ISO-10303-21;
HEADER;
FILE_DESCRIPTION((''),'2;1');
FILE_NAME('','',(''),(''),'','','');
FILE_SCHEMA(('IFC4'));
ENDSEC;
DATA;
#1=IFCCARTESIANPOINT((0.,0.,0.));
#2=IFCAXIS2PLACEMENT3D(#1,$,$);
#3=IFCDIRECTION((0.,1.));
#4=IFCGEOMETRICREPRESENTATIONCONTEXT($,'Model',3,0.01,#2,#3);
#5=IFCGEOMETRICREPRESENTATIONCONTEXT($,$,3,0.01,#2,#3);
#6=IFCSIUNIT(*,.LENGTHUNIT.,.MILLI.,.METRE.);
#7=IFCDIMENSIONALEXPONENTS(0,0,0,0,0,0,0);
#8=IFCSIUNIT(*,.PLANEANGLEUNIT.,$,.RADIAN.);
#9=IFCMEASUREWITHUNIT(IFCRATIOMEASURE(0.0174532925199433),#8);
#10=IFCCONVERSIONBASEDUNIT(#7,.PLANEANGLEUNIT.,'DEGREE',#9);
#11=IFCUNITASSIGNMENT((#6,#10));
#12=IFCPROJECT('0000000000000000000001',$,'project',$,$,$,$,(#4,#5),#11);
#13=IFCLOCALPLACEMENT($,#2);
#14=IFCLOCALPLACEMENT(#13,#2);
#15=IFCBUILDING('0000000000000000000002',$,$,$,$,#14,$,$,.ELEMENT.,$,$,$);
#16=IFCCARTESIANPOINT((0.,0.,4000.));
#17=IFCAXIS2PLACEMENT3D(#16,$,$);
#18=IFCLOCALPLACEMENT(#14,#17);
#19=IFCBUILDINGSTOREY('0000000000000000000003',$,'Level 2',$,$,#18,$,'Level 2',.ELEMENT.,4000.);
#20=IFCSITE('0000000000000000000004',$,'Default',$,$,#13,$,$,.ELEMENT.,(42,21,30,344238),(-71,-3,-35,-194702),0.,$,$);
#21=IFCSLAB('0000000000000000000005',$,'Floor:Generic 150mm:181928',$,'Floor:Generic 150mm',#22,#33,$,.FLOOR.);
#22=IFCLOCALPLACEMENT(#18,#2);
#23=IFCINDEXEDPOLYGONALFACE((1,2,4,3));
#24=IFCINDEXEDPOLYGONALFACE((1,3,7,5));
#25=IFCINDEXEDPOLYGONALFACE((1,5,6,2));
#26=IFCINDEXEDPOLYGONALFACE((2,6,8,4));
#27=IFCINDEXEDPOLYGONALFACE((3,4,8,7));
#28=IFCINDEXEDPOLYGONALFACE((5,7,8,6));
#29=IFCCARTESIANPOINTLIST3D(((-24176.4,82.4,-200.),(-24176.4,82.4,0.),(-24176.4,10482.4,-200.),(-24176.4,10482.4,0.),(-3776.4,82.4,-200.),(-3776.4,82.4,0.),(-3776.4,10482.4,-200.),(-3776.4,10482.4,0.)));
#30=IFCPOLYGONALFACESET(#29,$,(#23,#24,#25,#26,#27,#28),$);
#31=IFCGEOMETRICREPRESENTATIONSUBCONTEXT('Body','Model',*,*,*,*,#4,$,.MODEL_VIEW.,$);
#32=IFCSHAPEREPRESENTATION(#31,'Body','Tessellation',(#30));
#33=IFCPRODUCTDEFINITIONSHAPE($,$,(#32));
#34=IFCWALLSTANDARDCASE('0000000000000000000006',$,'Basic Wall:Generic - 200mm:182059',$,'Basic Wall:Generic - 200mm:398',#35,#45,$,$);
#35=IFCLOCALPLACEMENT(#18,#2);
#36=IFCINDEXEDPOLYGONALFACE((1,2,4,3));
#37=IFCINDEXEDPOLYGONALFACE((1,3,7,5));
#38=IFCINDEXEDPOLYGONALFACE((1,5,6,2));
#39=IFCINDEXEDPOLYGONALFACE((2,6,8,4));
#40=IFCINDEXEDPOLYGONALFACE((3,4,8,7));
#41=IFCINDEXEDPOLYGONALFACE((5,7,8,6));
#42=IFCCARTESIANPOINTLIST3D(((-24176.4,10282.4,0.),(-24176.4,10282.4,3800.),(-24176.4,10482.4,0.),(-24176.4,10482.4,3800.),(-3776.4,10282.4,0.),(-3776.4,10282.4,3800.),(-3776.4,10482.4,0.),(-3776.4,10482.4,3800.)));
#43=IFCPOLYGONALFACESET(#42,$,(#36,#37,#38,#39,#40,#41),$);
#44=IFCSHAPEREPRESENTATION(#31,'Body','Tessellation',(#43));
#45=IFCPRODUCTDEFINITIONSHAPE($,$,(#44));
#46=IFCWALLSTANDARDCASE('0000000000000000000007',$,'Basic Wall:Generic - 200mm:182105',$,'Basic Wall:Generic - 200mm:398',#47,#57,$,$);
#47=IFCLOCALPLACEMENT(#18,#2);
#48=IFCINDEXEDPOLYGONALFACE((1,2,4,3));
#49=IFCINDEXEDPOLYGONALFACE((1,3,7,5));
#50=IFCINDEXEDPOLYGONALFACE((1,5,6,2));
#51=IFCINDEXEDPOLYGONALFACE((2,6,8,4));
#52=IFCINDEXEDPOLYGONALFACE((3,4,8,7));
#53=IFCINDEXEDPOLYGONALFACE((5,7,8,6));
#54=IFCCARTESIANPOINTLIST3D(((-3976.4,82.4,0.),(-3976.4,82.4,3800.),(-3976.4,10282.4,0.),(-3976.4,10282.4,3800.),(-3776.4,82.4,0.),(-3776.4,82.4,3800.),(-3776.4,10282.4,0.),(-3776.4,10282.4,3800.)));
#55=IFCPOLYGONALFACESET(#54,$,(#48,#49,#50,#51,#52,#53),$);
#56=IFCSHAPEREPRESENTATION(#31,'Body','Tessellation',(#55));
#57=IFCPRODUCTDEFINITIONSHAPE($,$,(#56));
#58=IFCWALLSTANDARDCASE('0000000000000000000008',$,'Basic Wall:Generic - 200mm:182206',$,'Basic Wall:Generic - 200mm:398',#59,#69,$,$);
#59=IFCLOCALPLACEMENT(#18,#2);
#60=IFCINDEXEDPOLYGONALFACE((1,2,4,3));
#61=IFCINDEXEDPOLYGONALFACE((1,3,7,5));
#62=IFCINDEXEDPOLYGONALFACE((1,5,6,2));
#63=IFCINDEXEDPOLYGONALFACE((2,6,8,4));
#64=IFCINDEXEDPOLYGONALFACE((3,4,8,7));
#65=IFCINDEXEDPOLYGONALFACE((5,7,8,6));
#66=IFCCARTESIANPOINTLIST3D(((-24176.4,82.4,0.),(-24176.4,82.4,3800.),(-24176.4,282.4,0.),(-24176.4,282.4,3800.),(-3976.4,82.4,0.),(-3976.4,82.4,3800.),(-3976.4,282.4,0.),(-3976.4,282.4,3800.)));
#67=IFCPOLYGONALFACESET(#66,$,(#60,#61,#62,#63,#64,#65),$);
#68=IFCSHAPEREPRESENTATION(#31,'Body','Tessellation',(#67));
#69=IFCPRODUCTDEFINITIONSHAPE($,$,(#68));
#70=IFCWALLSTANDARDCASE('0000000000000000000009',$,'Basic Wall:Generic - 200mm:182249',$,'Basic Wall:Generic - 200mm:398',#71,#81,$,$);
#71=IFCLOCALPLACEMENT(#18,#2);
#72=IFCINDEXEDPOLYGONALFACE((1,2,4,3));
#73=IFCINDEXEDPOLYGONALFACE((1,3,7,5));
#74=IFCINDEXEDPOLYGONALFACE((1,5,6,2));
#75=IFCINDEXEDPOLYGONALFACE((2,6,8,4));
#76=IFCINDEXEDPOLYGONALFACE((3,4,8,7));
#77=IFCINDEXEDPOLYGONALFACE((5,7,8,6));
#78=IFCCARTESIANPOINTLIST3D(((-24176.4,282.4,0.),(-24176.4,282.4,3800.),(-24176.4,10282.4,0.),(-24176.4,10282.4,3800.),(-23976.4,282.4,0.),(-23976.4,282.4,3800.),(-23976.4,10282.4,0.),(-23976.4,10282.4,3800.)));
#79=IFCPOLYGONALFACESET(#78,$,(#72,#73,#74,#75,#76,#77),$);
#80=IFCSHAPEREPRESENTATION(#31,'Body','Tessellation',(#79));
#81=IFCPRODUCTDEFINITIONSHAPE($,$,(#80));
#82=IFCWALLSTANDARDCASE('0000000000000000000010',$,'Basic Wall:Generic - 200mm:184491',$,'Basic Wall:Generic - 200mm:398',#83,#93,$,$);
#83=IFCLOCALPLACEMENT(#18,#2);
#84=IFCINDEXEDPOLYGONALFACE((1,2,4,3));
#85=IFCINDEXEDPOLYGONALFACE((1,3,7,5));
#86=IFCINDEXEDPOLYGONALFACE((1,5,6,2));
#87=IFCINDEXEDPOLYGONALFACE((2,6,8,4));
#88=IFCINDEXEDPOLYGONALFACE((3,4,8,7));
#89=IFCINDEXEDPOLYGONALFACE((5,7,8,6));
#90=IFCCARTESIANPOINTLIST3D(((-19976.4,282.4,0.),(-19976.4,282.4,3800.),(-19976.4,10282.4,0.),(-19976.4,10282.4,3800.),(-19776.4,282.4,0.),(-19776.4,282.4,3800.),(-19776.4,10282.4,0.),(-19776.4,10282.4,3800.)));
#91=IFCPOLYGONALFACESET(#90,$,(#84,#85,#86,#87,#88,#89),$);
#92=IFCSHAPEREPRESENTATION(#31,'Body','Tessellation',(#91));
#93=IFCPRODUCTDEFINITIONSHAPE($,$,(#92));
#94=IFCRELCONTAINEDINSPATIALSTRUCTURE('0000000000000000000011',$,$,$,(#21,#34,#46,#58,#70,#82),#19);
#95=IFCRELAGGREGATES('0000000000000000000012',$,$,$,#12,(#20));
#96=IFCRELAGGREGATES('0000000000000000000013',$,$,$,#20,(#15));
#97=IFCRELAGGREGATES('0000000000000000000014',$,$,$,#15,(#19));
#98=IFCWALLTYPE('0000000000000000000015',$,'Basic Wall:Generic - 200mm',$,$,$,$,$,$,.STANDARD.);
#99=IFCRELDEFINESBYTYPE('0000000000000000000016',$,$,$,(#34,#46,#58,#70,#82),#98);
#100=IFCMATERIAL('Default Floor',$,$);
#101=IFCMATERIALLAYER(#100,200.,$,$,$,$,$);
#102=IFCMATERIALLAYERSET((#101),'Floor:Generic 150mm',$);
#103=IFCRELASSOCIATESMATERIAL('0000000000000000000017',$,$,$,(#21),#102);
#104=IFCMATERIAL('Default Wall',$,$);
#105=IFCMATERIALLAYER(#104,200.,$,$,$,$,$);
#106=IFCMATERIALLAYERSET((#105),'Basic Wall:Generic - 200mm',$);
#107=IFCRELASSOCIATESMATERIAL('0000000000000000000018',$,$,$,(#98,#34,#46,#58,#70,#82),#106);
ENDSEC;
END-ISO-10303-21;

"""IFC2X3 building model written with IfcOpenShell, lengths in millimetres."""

from ifc_helpers import new_model, entity, si_unit, converted_unit, direction, frame, frame_2d, origin, origin_2d_with_axis, place, context, subcontext, project, spatial, rectangle, extrude, material, layer, layer_set, layer_usage, type_object, element, save


model = new_model("IFC2X3")

# Units and contexts
model_context = context("Model", 3, precision=0.01, world=origin(), true_north=direction((0.0, 1.0)))
context_of_model = context(None, 3, precision=0.01, world=origin(), true_north=direction((0.0, 1.0)))
body_context = subcontext(model_context, "Body", "Model", "MODEL_VIEW")
ifc_project = project(units=[si_unit("LENGTHUNIT", "METRE", prefix="MILLI"), converted_unit("PLANEANGLEUNIT", "DEGREE", entity("IfcRatioMeasure", 0.0174532925199433), si_unit("PLANEANGLEUNIT", "RADIAN"), dimensions=[0, 0, 0, 0, 0, 0, 0])], contexts=[model_context, context_of_model])

# Site, building, storey
site_placement = place(None, origin())
site = spatial("IfcSite", under=ifc_project, at=site_placement, Name="Default", CompositionType="ELEMENT", RefLatitude=(42, 21, 30, 344238), RefLongitude=(-71, -3, -35, -194702), RefElevation=0.0)
building_placement = place(site_placement, origin())
building = spatial("IfcBuilding", under=site, at=building_placement, CompositionType="ELEMENT")
storey_placement = place(building_placement, frame((0.0, 0.0, 4000.0)))
storey = spatial("IfcBuildingStorey", under=building, at=storey_placement, Name="Level 2", LongName="Level 2", CompositionType="ELEMENT", Elevation=4000.0)

# Slab
ifc_material_1 = material(Name="Default Floor")
ifc_layer_1 = layer(ifc_material_1, 200.0)
ifc_layer_set_1 = layer_set([ifc_layer_1], Name="Floor:Generic 150mm")
ifc_layer_usage_1 = layer_usage(ifc_layer_set_1, "AXIS3", "POSITIVE", 0.0)
slab_placement = place(storey_placement, origin())
element("IfcSlab", 1, at=slab_placement, inside=storey, material=ifc_layer_usage_1, Name="Floor:Generic 150mm:181928", ObjectType="Floor:Generic 150mm", PredefinedType="FLOOR", context=body_context, shape_type="SweptSolid", body=[
    extrude(rectangle(XDim=10400.0, YDim=20400.0, at=origin_2d_with_axis()), frame((-13976.4, 5282.4, 0.0), z_axis=(0.0, 0.0, -1.0), x_axis=(0.0, 1.0, 0.0)), (0.0, 0.0, 1.0), 200.0),
])

# Walls
ifc_material_2 = material(Name="Default Wall")
ifc_layer_2 = layer(ifc_material_2, 200.0)
ifc_layer_set_2 = layer_set([ifc_layer_2], Name="Basic Wall:Generic - 200mm")
ifc_layer_usage_2 = layer_usage(ifc_layer_set_2, "AXIS2", "NEGATIVE", 100.0)
wall_type = type_object("IfcWallType", Name="Basic Wall:Generic - 200mm", PredefinedType="STANDARD", material=ifc_layer_set_2)
wall_1_placement = place(storey_placement, frame((-24176.4, 10382.4, 0.0)))
element("IfcWallStandardCase", 2, at=wall_1_placement, inside=storey, type_object=wall_type, material=ifc_layer_usage_2, Name="Basic Wall:Generic - 200mm:182059", ObjectType="Basic Wall:Generic - 200mm:398", context=body_context, shape_type="SweptSolid", body=[
    extrude(rectangle(XDim=20400.0, YDim=200.0, at=frame_2d((10200.0, 0.0), x_axis=(-1.0, 0.0))), origin(), (0.0, 0.0, 1.0), 3800.0),
])
ifc_layer_usage_3 = layer_usage(ifc_layer_set_2, "AXIS2", "NEGATIVE", 100.0)
wall_2_placement = place(storey_placement, frame((-3876.4, 10282.4, 0.0), z_axis=(0.0, 0.0, 1.0), x_axis=(0.0, -1.0, 0.0)))
element("IfcWallStandardCase", 3, at=wall_2_placement, inside=storey, type_object=wall_type, material=ifc_layer_usage_3, Name="Basic Wall:Generic - 200mm:182105", ObjectType="Basic Wall:Generic - 200mm:398", context=body_context, shape_type="SweptSolid", body=[
    extrude(rectangle(XDim=10200.0, YDim=200.0, at=frame_2d((5100.0, 0.0), x_axis=(-1.0, 0.0))), origin(), (0.0, 0.0, 1.0), 3800.0),
])
ifc_layer_usage_4 = layer_usage(ifc_layer_set_2, "AXIS2", "NEGATIVE", 100.0)
wall_3_placement = place(storey_placement, frame((-3976.4, 182.4, 0.0), z_axis=(0.0, 0.0, 1.0), x_axis=(-1.0, 0.0, 0.0)))
element("IfcWallStandardCase", 4, at=wall_3_placement, inside=storey, type_object=wall_type, material=ifc_layer_usage_4, Name="Basic Wall:Generic - 200mm:182206", ObjectType="Basic Wall:Generic - 200mm:398", context=body_context, shape_type="SweptSolid", body=[
    extrude(rectangle(XDim=20200.0, YDim=200.0, at=frame_2d((10100.0, 0.0), x_axis=(-1.0, 0.0))), origin(), (0.0, 0.0, 1.0), 3800.0),
])
ifc_layer_usage_5 = layer_usage(ifc_layer_set_2, "AXIS2", "NEGATIVE", 100.0)
wall_4_placement = place(storey_placement, frame((-24076.4, 282.4, 0.0), z_axis=(0.0, 0.0, 1.0), x_axis=(0.0, 1.0, 0.0)))
element("IfcWallStandardCase", 5, at=wall_4_placement, inside=storey, type_object=wall_type, material=ifc_layer_usage_5, Name="Basic Wall:Generic - 200mm:182249", ObjectType="Basic Wall:Generic - 200mm:398", context=body_context, shape_type="SweptSolid", body=[
    extrude(rectangle(XDim=10000.0, YDim=200.0, at=frame_2d((5000.0, 0.0), x_axis=(-1.0, 0.0))), origin(), (0.0, 0.0, 1.0), 3800.0),
])
ifc_layer_usage_6 = layer_usage(ifc_layer_set_2, "AXIS2", "NEGATIVE", 100.0)
wall_5_placement = place(storey_placement, frame((-19876.4, 10282.4, 0.0), z_axis=(0.0, 0.0, 1.0), x_axis=(0.0, -1.0, 0.0)))
element("IfcWallStandardCase", 6, at=wall_5_placement, inside=storey, type_object=wall_type, material=ifc_layer_usage_6, Name="Basic Wall:Generic - 200mm:184491", ObjectType="Basic Wall:Generic - 200mm:398", context=body_context, shape_type="SweptSolid", body=[
    extrude(rectangle(XDim=10000.0, YDim=200.0, at=frame_2d((5000.0, 0.0), x_axis=(-1.0, 0.0))), origin(), (0.0, 0.0, 1.0), 3800.0),
])

save(model, "model.ifc")
